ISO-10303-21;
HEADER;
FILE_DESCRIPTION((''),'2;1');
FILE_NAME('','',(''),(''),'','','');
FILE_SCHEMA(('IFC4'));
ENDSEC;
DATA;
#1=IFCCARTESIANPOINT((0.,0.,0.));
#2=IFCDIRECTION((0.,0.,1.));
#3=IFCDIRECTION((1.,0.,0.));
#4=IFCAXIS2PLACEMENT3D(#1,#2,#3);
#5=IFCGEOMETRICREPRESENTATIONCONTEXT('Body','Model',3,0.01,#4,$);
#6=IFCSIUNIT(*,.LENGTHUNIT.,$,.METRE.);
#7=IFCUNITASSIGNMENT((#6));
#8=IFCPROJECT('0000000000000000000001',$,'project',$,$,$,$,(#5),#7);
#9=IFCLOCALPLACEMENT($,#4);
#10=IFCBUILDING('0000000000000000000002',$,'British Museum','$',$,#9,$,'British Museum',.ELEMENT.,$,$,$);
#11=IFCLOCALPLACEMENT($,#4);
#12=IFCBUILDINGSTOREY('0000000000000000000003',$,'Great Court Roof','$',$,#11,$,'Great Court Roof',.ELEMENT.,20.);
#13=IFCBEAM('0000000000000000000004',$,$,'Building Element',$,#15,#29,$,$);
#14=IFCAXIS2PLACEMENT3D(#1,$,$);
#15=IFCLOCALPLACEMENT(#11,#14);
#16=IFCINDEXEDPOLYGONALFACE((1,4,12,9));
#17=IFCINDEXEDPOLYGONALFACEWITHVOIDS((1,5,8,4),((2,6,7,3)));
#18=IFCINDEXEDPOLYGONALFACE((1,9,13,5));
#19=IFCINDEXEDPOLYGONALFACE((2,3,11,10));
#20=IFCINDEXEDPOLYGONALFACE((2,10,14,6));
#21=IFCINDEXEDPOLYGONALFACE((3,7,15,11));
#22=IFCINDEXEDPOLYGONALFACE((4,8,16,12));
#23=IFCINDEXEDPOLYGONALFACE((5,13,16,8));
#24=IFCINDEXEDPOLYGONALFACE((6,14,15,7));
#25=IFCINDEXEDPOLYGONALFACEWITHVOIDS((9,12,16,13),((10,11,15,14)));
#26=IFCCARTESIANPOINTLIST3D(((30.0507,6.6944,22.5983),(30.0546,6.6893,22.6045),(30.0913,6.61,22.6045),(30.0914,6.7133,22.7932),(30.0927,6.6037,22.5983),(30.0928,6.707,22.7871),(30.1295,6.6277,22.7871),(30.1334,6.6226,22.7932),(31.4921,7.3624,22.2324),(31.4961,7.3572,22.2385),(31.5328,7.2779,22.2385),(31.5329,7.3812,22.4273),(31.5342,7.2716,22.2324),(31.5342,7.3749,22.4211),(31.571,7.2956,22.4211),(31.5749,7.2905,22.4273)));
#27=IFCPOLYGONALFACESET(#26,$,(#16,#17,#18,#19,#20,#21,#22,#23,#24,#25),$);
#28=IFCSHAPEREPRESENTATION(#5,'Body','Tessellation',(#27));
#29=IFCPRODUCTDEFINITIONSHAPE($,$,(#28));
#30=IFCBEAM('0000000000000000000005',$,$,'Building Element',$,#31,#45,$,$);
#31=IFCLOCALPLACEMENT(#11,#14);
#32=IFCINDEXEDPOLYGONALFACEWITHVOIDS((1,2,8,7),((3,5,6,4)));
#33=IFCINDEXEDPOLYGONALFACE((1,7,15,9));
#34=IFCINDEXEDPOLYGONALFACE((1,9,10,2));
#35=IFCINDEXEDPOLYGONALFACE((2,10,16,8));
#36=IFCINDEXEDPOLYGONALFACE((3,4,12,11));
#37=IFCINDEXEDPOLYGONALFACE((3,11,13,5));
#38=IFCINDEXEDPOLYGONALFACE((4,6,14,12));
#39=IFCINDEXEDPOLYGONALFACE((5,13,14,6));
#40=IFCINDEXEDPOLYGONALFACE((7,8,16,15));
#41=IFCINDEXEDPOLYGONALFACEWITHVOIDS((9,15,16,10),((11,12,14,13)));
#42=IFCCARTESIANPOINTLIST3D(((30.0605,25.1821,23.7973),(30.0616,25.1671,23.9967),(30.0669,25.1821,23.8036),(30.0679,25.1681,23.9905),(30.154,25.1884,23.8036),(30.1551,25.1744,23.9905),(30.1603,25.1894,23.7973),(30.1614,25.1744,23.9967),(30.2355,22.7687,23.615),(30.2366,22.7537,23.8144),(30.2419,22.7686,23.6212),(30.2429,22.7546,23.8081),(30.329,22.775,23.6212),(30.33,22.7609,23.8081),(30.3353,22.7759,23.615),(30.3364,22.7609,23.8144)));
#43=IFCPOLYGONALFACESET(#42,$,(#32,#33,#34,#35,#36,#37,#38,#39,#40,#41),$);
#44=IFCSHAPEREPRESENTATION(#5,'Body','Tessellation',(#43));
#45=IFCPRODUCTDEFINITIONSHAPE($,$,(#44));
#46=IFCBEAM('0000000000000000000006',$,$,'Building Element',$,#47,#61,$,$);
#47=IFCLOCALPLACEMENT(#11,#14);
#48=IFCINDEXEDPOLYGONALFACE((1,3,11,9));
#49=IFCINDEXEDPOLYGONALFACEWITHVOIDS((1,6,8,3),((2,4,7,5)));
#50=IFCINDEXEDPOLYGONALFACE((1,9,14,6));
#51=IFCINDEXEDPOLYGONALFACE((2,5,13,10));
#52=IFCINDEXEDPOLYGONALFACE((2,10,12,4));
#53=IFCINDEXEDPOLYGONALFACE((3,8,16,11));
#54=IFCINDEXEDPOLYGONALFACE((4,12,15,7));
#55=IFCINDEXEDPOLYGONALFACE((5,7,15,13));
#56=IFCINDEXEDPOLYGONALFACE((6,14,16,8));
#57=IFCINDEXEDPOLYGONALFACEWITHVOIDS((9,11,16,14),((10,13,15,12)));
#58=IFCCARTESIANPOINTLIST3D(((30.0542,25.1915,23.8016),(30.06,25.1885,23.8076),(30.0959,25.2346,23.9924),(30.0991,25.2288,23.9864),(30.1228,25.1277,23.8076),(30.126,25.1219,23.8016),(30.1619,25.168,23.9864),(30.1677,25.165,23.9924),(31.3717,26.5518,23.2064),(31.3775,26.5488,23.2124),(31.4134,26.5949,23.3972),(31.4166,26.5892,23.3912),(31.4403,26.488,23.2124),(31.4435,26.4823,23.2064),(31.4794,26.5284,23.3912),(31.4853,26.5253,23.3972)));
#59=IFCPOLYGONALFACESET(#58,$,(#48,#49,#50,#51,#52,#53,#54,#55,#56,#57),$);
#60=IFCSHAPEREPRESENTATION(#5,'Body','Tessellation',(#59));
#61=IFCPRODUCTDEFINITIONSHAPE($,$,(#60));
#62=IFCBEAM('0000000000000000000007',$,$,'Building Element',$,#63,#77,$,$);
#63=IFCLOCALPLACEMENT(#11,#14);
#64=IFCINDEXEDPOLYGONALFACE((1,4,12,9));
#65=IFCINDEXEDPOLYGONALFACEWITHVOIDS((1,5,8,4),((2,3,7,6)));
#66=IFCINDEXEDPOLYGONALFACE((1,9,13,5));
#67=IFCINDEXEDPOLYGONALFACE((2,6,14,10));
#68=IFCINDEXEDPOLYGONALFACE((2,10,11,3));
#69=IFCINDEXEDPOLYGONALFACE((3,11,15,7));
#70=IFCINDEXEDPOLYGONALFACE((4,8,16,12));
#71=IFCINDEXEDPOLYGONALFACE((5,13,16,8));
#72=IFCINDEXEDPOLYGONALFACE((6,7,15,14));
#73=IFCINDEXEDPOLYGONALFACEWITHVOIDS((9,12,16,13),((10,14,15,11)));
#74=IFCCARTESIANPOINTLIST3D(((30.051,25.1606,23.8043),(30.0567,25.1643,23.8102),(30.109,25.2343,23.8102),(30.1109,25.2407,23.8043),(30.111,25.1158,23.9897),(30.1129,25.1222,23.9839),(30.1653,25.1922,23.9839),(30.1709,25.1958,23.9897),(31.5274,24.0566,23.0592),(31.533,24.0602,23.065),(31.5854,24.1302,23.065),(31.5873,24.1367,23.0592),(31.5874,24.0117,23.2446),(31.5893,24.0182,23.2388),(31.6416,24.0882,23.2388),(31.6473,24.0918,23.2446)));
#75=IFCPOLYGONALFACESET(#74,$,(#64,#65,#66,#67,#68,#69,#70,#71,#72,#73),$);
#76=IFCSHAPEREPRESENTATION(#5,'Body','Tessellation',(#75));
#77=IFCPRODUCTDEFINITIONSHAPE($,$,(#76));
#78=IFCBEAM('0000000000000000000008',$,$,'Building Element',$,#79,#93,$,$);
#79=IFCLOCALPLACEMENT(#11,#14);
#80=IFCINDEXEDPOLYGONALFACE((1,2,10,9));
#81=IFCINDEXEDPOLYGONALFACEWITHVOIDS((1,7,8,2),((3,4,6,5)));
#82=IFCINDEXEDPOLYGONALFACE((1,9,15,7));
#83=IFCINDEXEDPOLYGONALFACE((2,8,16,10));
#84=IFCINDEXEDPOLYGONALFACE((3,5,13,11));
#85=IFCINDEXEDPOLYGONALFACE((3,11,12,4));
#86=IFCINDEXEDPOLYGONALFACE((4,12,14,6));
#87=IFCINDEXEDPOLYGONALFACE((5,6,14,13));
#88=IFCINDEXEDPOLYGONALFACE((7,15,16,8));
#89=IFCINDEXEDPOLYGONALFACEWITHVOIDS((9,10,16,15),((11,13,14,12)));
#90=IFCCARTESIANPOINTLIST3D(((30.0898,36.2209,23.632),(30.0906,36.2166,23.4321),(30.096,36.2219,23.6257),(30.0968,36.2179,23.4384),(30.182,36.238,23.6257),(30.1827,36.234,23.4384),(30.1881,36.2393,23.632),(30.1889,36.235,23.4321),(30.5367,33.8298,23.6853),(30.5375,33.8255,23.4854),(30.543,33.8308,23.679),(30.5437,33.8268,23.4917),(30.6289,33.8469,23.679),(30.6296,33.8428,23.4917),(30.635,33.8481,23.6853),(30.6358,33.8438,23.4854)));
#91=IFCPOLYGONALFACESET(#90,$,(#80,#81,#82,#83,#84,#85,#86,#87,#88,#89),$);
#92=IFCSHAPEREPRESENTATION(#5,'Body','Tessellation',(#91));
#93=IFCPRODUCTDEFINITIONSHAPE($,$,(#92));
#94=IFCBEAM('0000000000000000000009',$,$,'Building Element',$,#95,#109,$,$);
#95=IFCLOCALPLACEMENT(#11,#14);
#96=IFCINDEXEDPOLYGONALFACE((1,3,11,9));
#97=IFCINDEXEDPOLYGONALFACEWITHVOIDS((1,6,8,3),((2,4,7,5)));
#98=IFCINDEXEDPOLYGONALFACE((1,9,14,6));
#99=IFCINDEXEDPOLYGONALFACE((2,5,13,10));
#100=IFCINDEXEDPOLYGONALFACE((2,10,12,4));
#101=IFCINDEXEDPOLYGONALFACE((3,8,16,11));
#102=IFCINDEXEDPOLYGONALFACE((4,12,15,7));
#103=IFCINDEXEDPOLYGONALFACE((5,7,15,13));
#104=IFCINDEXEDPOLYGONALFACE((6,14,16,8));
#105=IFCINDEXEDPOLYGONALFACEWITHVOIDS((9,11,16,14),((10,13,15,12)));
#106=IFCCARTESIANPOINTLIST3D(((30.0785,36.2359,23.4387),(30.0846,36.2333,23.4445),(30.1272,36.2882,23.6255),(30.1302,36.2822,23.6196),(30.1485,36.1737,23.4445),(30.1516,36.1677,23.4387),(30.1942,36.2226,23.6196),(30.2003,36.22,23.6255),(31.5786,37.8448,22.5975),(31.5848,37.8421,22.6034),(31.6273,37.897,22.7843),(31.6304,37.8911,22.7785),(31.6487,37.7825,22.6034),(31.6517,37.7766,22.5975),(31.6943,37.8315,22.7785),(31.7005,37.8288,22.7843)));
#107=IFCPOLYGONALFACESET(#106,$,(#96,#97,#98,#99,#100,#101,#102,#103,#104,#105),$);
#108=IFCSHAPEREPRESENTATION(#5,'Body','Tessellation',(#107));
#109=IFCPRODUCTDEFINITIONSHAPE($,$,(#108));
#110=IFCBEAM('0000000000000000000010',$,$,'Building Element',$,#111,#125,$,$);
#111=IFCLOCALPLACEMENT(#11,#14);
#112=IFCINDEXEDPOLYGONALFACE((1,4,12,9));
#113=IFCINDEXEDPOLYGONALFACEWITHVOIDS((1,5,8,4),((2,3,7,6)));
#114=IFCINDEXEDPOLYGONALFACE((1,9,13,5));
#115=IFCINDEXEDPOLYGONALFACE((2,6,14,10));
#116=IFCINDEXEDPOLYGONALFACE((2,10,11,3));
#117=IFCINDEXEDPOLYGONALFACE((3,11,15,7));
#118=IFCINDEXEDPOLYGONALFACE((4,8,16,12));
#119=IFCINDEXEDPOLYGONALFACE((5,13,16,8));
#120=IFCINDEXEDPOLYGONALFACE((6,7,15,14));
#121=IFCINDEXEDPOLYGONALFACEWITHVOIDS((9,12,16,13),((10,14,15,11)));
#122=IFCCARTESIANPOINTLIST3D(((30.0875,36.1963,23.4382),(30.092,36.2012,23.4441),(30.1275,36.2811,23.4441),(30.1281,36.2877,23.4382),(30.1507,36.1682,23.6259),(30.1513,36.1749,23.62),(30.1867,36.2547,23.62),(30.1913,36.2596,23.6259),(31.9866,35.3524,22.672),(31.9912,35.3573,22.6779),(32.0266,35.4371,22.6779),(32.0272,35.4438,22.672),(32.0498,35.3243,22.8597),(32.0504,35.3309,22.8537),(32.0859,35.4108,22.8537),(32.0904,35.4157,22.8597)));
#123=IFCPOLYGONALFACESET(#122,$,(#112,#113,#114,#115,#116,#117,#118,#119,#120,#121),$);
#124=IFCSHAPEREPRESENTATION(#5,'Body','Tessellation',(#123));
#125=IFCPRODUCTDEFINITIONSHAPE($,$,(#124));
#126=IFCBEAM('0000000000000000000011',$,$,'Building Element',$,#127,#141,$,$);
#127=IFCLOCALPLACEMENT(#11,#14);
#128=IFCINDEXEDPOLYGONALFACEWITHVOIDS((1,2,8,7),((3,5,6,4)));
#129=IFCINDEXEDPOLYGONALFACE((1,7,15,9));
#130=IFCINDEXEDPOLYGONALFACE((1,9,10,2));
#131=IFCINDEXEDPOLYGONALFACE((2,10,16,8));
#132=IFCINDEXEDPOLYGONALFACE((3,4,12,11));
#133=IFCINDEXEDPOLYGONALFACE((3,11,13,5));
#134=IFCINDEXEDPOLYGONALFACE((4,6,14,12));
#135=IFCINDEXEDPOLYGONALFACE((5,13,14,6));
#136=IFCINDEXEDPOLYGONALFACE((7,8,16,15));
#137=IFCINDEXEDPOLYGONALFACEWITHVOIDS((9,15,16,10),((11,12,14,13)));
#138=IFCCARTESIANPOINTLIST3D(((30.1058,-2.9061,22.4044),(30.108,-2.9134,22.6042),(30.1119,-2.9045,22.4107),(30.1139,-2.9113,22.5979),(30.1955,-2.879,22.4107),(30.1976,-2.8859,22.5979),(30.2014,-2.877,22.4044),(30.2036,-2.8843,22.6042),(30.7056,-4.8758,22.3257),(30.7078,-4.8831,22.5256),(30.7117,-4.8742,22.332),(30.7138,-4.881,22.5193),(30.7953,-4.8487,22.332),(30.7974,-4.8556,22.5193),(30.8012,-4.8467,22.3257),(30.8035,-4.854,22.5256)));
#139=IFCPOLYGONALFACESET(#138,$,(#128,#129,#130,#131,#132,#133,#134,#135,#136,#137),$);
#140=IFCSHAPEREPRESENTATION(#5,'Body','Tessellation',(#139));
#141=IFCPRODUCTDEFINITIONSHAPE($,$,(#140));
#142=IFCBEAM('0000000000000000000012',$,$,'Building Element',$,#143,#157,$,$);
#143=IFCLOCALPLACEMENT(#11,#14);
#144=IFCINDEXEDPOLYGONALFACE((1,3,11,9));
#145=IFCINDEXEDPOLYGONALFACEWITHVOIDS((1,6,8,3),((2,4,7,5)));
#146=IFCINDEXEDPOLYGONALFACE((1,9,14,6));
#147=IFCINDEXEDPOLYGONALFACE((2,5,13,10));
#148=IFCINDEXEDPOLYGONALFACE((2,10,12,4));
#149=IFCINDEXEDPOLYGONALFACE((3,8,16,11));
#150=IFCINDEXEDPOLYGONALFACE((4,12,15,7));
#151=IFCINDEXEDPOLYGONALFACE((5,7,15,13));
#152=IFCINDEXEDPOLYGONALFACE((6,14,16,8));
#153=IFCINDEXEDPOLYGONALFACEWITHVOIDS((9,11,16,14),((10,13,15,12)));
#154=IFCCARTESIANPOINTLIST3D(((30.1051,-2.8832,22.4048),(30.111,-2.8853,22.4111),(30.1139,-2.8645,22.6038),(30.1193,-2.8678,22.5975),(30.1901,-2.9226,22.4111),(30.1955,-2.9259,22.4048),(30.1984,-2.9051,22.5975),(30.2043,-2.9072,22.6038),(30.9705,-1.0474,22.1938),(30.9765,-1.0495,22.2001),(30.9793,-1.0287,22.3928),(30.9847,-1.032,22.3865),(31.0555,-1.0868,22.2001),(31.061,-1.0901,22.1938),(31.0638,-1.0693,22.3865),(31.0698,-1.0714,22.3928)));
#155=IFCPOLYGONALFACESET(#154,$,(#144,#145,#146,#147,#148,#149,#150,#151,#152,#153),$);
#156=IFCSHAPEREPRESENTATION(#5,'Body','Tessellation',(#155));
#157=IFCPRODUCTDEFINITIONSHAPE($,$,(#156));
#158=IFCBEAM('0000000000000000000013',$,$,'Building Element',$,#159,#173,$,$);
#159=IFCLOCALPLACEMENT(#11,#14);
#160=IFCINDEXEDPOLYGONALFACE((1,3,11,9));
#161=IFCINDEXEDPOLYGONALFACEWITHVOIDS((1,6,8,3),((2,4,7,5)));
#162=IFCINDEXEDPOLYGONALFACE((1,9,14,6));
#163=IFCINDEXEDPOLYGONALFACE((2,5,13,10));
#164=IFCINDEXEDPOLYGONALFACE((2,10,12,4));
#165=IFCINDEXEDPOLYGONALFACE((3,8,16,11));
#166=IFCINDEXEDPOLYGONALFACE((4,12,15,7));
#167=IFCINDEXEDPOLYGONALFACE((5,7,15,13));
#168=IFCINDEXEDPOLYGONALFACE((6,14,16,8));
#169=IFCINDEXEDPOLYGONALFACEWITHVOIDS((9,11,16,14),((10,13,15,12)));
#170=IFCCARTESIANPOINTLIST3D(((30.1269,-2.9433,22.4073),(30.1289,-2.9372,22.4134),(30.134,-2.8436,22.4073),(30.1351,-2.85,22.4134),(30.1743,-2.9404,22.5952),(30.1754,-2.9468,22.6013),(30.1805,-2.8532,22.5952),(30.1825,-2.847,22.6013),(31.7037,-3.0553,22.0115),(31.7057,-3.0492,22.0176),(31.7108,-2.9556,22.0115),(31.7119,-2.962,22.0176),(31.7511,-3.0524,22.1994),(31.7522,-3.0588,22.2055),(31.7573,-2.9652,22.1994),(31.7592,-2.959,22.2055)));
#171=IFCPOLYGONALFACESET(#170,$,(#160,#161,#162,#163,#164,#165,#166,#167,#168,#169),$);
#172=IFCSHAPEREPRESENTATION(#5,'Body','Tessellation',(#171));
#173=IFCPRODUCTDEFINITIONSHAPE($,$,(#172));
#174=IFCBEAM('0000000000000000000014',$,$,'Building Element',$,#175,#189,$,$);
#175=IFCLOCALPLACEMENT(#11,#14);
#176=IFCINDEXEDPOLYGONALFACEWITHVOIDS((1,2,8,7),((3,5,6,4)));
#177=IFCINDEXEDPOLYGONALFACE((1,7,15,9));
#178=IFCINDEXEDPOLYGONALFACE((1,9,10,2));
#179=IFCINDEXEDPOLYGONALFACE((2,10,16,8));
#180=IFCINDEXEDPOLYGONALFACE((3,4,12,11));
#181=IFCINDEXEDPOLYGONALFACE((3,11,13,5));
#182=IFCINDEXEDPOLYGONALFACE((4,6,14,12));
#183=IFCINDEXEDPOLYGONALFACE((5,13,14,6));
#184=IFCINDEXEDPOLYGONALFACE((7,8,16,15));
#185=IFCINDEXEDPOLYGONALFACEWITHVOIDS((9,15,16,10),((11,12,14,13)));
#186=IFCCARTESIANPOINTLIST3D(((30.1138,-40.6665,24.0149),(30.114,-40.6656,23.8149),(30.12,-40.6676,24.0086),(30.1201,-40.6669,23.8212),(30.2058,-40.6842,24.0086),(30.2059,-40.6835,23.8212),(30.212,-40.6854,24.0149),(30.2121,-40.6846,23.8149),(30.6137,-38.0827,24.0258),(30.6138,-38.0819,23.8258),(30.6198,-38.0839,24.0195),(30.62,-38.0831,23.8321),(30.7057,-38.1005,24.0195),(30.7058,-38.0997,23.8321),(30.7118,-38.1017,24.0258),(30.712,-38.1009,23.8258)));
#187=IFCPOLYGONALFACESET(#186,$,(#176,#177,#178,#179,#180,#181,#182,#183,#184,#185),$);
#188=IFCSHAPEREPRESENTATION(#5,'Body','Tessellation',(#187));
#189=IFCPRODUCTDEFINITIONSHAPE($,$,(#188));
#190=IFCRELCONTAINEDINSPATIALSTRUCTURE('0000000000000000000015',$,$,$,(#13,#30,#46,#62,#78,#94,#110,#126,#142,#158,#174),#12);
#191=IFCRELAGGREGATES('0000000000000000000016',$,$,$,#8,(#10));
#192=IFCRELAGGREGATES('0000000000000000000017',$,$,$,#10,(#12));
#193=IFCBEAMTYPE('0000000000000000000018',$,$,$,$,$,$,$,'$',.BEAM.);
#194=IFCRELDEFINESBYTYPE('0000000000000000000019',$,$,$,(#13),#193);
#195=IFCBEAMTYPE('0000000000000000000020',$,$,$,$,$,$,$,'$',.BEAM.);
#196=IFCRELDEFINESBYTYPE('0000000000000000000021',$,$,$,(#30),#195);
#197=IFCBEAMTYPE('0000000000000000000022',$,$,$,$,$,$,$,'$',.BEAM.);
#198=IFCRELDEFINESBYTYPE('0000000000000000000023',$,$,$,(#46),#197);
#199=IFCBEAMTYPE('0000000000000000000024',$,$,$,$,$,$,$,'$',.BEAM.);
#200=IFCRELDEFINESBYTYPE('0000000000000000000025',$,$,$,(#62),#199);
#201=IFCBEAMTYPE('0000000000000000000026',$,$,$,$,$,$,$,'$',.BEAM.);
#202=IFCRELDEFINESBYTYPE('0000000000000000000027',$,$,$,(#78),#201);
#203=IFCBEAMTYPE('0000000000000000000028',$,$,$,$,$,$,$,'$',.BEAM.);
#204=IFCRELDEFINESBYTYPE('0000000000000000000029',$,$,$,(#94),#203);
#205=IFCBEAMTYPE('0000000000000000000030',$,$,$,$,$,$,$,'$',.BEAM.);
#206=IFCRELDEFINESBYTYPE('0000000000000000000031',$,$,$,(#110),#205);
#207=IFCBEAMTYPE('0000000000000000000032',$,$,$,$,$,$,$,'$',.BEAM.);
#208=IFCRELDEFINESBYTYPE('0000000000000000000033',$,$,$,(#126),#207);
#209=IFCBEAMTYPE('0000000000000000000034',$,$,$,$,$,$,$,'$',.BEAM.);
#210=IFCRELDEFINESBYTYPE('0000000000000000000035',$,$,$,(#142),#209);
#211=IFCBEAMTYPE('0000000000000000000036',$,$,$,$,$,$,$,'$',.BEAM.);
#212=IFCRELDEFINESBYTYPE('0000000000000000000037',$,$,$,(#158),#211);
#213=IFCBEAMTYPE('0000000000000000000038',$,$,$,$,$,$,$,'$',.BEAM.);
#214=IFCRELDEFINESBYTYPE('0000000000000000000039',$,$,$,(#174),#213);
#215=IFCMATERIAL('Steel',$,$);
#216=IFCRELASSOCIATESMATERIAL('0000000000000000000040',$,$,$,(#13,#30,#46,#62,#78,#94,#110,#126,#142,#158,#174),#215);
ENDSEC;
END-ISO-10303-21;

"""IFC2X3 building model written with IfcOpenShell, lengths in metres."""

from ifc_helpers import new_model, si_unit, frame, origin_with_axes, origin_2d, place, context, project, spatial, hollow_rectangle, extrude, material, type_object, element, save


model = new_model("IFC2X3")

# Units and contexts
model_context = context("Model", 3, precision=0.01, world=origin_with_axes(), identifier="Body")
ifc_project = project(units=[si_unit("LENGTHUNIT", "METRE")], contexts=[model_context])

# Building, storey
building_placement = place(None, origin_with_axes())
building = spatial("IfcBuilding", under=ifc_project, at=building_placement, Name="British Museum", Description="$", LongName="British Museum", CompositionType="ELEMENT")
storey_placement = place(None, origin_with_axes())
storey = spatial("IfcBuildingStorey", under=building, at=storey_placement, Name="Great Court Roof", Description="$", LongName="Great Court Roof", CompositionType="ELEMENT", Elevation=20.0)

# Beams
ifc_material = material(Name="Steel")
beam_type_1 = type_object("IfcBeamType", ElementType="$", PredefinedType="BEAM")
beam_1_placement = place(None, origin_with_axes())
element("IfcBeam", 1, at=beam_1_placement, inside=storey, type_object=beam_type_1, material=ifc_material, Description="Building Element", context=model_context, shape_type="SweptSolid", body=[
    extrude(hollow_rectangle(XDim=0.1, YDim=0.2, WallThickness=0.0063, InnerFilletRadius=-0.0063, OuterFilletRadius=0.0, at=origin_2d()), frame((30.0921, 6.6585, 22.6958), z_axis=(0.884169, 0.4097, -0.22448), x_axis=(-0.42043, 0.907325, 0.0)), (0.0, 0.0, 1.0), 1.6303),
])
beam_type_2 = type_object("IfcBeamType", ElementType="$", PredefinedType="BEAM")
beam_2_placement = place(None, origin_with_axes())
element("IfcBeam", 2, at=beam_2_placement, inside=storey, type_object=beam_type_2, material=ifc_material, Description="Building Element", context=model_context, shape_type="SweptSolid", body=[
    extrude(hollow_rectangle(XDim=0.1, YDim=0.2, WallThickness=0.0063, InnerFilletRadius=-0.0063, OuterFilletRadius=0.0, at=origin_2d()), frame((30.111, 25.1782, 23.897), z_axis=(0.072109, -0.994562, -0.075145), x_axis=(0.997382, 0.072314, 0.0)), (0.0, 0.0, 1.0), 2.4267),
])
beam_type_3 = type_object("IfcBeamType", ElementType="$", PredefinedType="BEAM")
beam_3_placement = place(None, origin_with_axes())
element("IfcBeam", 3, at=beam_3_placement, inside=storey, type_object=beam_type_3, material=ifc_material, Description="Building Element", context=model_context, shape_type="SweptSolid", body=[
    extrude(hollow_rectangle(XDim=0.1, YDim=0.2, WallThickness=0.0063, InnerFilletRadius=-0.0063, OuterFilletRadius=0.0, at=origin_2d()), frame((30.111, 25.1782, 23.897), z_axis=(0.663697, 0.685271, -0.29985), x_axis=(-0.718324, 0.695709, 0.0)), (0.0, 0.0, 1.0), 1.9851),
])
beam_type_4 = type_object("IfcBeamType", ElementType="$", PredefinedType="BEAM")
beam_4_placement = place(None, origin_with_axes())
element("IfcBeam", 4, at=beam_4_placement, inside=storey, type_object=beam_type_4, material=ifc_material, Description="Building Element", context=model_context, shape_type="SweptSolid", body=[
    extrude(hollow_rectangle(XDim=0.1, YDim=0.2, WallThickness=0.0063, InnerFilletRadius=-0.0063, OuterFilletRadius=0.0, at=origin_2d()), frame((30.111, 25.1782, 23.897), z_axis=(0.742483, -0.555237, -0.37474), x_axis=(0.598877, 0.800841, 0.0)), (0.0, 0.0, 1.0), 1.9884),
])
beam_type_5 = type_object("IfcBeamType", ElementType="$", PredefinedType="BEAM")
beam_5_placement = place(None, origin_with_axes())
element("IfcBeam", 5, at=beam_5_placement, inside=storey, type_object=beam_type_5, material=ifc_material, Description="Building Element", context=model_context, shape_type="SweptSolid", body=[
    extrude(hollow_rectangle(XDim=0.1, YDim=0.2, WallThickness=0.0063, InnerFilletRadius=-0.0063, OuterFilletRadius=0.0, at=origin_2d()), frame((30.1394, 36.228, 23.5321), z_axis=(0.183675, -0.982743, 0.021899), x_axis=(0.982979, 0.183719, 0.0)), (0.0, 0.0, 1.0), 2.4331),
])
beam_type_6 = type_object("IfcBeamType", ElementType="$", PredefinedType="BEAM")
beam_6_placement = place(None, origin_with_axes())
element("IfcBeam", 6, at=beam_6_placement, inside=storey, type_object=beam_type_6, material=ifc_material, Description="Building Element", context=model_context, shape_type="SweptSolid", body=[
    extrude(hollow_rectangle(XDim=0.1, YDim=0.2, WallThickness=0.0063, InnerFilletRadius=-0.0063, OuterFilletRadius=0.0, at=origin_2d()), frame((30.1394, 36.228, 23.5321), z_axis=(0.63699, 0.683144, -0.357153), x_axis=(-0.731382, 0.681968, 0.0)), (0.0, 0.0, 1.0), 2.3551),
])
beam_type_7 = type_object("IfcBeamType", ElementType="$", PredefinedType="BEAM")
beam_7_placement = place(None, origin_with_axes())
element("IfcBeam", 7, at=beam_7_placement, inside=storey, type_object=beam_type_7, material=ifc_material, Description="Building Element", context=model_context, shape_type="SweptSolid", body=[
    extrude(hollow_rectangle(XDim=0.1, YDim=0.2, WallThickness=0.0063, InnerFilletRadius=-0.0063, OuterFilletRadius=0.0, at=origin_2d()), frame((30.1394, 36.228, 23.5321), z_axis=(0.857415, -0.381011, -0.345933), x_axis=(0.406083, 0.913836, 0.0)), (0.0, 0.0, 1.0), 2.215),
])
beam_type_8 = type_object("IfcBeamType", ElementType="$", PredefinedType="BEAM")
beam_8_placement = place(None, origin_with_axes())
element("IfcBeam", 8, at=beam_8_placement, inside=storey, type_object=beam_type_8, material=ifc_material, Description="Building Element", context=model_context, shape_type="SweptSolid", body=[
    extrude(hollow_rectangle(XDim=0.1, YDim=0.2, WallThickness=0.0063, InnerFilletRadius=-0.0063, OuterFilletRadius=0.0, at=origin_2d()), frame((30.1547, -2.8952, 22.5043), z_axis=(0.291099, -0.955931, -0.038177), x_axis=(0.956628, 0.291311, 0.0)), (0.0, 0.0, 1.0), 2.0605),
])
beam_type_9 = type_object("IfcBeamType", ElementType="$", PredefinedType="BEAM")
beam_9_placement = place(None, origin_with_axes())
element("IfcBeam", 9, at=beam_9_placement, inside=storey, type_object=beam_type_9, material=ifc_material, Description="Building Element", context=model_context, shape_type="SweptSolid", body=[
    extrude(hollow_rectangle(XDim=0.1, YDim=0.2, WallThickness=0.0063, InnerFilletRadius=-0.0063, OuterFilletRadius=0.0, at=origin_2d()), frame((30.1547, -2.8952, 22.5043), z_axis=(0.42413, 0.899679, -0.103401), x_axis=(-0.904527, 0.426416, 0.0)), (0.0, 0.0, 1.0), 2.0405),
])
beam_type_10 = type_object("IfcBeamType", ElementType="$", PredefinedType="BEAM")
beam_10_placement = place(None, origin_with_axes())
element("IfcBeam", 10, at=beam_10_placement, inside=storey, type_object=beam_type_10, material=ifc_material, Description="Building Element", context=model_context, shape_type="SweptSolid", body=[
    extrude(hollow_rectangle(XDim=0.1, YDim=0.2, WallThickness=0.0063, InnerFilletRadius=-0.0063, OuterFilletRadius=0.0, at=origin_2d()), frame((30.1547, -2.8952, 22.5043), z_axis=(0.967616, -0.068733, -0.24289), x_axis=(0.070855, 0.997487, 0.0)), (0.0, 0.0, 1.0), 1.6295),
])
beam_type_11 = type_object("IfcBeamType", ElementType="$", PredefinedType="BEAM")
beam_11_placement = place(None, origin_with_axes())
element("IfcBeam", 11, at=beam_11_placement, inside=storey, type_object=beam_type_11, material=ifc_material, Description="Building Element", context=model_context, shape_type="SweptSolid", body=[
    extrude(hollow_rectangle(XDim=0.1, YDim=0.2, WallThickness=0.0063, InnerFilletRadius=-0.0063, OuterFilletRadius=0.0, at=origin_2d()), frame((30.163, -40.6755, 23.9149), z_axis=(0.189937, 0.981788, 0.004154), x_axis=(-0.981796, 0.189939, 0.0)), (0.0, 0.0, 1.0), 2.6317),
])

save(model, "model.ifc")
